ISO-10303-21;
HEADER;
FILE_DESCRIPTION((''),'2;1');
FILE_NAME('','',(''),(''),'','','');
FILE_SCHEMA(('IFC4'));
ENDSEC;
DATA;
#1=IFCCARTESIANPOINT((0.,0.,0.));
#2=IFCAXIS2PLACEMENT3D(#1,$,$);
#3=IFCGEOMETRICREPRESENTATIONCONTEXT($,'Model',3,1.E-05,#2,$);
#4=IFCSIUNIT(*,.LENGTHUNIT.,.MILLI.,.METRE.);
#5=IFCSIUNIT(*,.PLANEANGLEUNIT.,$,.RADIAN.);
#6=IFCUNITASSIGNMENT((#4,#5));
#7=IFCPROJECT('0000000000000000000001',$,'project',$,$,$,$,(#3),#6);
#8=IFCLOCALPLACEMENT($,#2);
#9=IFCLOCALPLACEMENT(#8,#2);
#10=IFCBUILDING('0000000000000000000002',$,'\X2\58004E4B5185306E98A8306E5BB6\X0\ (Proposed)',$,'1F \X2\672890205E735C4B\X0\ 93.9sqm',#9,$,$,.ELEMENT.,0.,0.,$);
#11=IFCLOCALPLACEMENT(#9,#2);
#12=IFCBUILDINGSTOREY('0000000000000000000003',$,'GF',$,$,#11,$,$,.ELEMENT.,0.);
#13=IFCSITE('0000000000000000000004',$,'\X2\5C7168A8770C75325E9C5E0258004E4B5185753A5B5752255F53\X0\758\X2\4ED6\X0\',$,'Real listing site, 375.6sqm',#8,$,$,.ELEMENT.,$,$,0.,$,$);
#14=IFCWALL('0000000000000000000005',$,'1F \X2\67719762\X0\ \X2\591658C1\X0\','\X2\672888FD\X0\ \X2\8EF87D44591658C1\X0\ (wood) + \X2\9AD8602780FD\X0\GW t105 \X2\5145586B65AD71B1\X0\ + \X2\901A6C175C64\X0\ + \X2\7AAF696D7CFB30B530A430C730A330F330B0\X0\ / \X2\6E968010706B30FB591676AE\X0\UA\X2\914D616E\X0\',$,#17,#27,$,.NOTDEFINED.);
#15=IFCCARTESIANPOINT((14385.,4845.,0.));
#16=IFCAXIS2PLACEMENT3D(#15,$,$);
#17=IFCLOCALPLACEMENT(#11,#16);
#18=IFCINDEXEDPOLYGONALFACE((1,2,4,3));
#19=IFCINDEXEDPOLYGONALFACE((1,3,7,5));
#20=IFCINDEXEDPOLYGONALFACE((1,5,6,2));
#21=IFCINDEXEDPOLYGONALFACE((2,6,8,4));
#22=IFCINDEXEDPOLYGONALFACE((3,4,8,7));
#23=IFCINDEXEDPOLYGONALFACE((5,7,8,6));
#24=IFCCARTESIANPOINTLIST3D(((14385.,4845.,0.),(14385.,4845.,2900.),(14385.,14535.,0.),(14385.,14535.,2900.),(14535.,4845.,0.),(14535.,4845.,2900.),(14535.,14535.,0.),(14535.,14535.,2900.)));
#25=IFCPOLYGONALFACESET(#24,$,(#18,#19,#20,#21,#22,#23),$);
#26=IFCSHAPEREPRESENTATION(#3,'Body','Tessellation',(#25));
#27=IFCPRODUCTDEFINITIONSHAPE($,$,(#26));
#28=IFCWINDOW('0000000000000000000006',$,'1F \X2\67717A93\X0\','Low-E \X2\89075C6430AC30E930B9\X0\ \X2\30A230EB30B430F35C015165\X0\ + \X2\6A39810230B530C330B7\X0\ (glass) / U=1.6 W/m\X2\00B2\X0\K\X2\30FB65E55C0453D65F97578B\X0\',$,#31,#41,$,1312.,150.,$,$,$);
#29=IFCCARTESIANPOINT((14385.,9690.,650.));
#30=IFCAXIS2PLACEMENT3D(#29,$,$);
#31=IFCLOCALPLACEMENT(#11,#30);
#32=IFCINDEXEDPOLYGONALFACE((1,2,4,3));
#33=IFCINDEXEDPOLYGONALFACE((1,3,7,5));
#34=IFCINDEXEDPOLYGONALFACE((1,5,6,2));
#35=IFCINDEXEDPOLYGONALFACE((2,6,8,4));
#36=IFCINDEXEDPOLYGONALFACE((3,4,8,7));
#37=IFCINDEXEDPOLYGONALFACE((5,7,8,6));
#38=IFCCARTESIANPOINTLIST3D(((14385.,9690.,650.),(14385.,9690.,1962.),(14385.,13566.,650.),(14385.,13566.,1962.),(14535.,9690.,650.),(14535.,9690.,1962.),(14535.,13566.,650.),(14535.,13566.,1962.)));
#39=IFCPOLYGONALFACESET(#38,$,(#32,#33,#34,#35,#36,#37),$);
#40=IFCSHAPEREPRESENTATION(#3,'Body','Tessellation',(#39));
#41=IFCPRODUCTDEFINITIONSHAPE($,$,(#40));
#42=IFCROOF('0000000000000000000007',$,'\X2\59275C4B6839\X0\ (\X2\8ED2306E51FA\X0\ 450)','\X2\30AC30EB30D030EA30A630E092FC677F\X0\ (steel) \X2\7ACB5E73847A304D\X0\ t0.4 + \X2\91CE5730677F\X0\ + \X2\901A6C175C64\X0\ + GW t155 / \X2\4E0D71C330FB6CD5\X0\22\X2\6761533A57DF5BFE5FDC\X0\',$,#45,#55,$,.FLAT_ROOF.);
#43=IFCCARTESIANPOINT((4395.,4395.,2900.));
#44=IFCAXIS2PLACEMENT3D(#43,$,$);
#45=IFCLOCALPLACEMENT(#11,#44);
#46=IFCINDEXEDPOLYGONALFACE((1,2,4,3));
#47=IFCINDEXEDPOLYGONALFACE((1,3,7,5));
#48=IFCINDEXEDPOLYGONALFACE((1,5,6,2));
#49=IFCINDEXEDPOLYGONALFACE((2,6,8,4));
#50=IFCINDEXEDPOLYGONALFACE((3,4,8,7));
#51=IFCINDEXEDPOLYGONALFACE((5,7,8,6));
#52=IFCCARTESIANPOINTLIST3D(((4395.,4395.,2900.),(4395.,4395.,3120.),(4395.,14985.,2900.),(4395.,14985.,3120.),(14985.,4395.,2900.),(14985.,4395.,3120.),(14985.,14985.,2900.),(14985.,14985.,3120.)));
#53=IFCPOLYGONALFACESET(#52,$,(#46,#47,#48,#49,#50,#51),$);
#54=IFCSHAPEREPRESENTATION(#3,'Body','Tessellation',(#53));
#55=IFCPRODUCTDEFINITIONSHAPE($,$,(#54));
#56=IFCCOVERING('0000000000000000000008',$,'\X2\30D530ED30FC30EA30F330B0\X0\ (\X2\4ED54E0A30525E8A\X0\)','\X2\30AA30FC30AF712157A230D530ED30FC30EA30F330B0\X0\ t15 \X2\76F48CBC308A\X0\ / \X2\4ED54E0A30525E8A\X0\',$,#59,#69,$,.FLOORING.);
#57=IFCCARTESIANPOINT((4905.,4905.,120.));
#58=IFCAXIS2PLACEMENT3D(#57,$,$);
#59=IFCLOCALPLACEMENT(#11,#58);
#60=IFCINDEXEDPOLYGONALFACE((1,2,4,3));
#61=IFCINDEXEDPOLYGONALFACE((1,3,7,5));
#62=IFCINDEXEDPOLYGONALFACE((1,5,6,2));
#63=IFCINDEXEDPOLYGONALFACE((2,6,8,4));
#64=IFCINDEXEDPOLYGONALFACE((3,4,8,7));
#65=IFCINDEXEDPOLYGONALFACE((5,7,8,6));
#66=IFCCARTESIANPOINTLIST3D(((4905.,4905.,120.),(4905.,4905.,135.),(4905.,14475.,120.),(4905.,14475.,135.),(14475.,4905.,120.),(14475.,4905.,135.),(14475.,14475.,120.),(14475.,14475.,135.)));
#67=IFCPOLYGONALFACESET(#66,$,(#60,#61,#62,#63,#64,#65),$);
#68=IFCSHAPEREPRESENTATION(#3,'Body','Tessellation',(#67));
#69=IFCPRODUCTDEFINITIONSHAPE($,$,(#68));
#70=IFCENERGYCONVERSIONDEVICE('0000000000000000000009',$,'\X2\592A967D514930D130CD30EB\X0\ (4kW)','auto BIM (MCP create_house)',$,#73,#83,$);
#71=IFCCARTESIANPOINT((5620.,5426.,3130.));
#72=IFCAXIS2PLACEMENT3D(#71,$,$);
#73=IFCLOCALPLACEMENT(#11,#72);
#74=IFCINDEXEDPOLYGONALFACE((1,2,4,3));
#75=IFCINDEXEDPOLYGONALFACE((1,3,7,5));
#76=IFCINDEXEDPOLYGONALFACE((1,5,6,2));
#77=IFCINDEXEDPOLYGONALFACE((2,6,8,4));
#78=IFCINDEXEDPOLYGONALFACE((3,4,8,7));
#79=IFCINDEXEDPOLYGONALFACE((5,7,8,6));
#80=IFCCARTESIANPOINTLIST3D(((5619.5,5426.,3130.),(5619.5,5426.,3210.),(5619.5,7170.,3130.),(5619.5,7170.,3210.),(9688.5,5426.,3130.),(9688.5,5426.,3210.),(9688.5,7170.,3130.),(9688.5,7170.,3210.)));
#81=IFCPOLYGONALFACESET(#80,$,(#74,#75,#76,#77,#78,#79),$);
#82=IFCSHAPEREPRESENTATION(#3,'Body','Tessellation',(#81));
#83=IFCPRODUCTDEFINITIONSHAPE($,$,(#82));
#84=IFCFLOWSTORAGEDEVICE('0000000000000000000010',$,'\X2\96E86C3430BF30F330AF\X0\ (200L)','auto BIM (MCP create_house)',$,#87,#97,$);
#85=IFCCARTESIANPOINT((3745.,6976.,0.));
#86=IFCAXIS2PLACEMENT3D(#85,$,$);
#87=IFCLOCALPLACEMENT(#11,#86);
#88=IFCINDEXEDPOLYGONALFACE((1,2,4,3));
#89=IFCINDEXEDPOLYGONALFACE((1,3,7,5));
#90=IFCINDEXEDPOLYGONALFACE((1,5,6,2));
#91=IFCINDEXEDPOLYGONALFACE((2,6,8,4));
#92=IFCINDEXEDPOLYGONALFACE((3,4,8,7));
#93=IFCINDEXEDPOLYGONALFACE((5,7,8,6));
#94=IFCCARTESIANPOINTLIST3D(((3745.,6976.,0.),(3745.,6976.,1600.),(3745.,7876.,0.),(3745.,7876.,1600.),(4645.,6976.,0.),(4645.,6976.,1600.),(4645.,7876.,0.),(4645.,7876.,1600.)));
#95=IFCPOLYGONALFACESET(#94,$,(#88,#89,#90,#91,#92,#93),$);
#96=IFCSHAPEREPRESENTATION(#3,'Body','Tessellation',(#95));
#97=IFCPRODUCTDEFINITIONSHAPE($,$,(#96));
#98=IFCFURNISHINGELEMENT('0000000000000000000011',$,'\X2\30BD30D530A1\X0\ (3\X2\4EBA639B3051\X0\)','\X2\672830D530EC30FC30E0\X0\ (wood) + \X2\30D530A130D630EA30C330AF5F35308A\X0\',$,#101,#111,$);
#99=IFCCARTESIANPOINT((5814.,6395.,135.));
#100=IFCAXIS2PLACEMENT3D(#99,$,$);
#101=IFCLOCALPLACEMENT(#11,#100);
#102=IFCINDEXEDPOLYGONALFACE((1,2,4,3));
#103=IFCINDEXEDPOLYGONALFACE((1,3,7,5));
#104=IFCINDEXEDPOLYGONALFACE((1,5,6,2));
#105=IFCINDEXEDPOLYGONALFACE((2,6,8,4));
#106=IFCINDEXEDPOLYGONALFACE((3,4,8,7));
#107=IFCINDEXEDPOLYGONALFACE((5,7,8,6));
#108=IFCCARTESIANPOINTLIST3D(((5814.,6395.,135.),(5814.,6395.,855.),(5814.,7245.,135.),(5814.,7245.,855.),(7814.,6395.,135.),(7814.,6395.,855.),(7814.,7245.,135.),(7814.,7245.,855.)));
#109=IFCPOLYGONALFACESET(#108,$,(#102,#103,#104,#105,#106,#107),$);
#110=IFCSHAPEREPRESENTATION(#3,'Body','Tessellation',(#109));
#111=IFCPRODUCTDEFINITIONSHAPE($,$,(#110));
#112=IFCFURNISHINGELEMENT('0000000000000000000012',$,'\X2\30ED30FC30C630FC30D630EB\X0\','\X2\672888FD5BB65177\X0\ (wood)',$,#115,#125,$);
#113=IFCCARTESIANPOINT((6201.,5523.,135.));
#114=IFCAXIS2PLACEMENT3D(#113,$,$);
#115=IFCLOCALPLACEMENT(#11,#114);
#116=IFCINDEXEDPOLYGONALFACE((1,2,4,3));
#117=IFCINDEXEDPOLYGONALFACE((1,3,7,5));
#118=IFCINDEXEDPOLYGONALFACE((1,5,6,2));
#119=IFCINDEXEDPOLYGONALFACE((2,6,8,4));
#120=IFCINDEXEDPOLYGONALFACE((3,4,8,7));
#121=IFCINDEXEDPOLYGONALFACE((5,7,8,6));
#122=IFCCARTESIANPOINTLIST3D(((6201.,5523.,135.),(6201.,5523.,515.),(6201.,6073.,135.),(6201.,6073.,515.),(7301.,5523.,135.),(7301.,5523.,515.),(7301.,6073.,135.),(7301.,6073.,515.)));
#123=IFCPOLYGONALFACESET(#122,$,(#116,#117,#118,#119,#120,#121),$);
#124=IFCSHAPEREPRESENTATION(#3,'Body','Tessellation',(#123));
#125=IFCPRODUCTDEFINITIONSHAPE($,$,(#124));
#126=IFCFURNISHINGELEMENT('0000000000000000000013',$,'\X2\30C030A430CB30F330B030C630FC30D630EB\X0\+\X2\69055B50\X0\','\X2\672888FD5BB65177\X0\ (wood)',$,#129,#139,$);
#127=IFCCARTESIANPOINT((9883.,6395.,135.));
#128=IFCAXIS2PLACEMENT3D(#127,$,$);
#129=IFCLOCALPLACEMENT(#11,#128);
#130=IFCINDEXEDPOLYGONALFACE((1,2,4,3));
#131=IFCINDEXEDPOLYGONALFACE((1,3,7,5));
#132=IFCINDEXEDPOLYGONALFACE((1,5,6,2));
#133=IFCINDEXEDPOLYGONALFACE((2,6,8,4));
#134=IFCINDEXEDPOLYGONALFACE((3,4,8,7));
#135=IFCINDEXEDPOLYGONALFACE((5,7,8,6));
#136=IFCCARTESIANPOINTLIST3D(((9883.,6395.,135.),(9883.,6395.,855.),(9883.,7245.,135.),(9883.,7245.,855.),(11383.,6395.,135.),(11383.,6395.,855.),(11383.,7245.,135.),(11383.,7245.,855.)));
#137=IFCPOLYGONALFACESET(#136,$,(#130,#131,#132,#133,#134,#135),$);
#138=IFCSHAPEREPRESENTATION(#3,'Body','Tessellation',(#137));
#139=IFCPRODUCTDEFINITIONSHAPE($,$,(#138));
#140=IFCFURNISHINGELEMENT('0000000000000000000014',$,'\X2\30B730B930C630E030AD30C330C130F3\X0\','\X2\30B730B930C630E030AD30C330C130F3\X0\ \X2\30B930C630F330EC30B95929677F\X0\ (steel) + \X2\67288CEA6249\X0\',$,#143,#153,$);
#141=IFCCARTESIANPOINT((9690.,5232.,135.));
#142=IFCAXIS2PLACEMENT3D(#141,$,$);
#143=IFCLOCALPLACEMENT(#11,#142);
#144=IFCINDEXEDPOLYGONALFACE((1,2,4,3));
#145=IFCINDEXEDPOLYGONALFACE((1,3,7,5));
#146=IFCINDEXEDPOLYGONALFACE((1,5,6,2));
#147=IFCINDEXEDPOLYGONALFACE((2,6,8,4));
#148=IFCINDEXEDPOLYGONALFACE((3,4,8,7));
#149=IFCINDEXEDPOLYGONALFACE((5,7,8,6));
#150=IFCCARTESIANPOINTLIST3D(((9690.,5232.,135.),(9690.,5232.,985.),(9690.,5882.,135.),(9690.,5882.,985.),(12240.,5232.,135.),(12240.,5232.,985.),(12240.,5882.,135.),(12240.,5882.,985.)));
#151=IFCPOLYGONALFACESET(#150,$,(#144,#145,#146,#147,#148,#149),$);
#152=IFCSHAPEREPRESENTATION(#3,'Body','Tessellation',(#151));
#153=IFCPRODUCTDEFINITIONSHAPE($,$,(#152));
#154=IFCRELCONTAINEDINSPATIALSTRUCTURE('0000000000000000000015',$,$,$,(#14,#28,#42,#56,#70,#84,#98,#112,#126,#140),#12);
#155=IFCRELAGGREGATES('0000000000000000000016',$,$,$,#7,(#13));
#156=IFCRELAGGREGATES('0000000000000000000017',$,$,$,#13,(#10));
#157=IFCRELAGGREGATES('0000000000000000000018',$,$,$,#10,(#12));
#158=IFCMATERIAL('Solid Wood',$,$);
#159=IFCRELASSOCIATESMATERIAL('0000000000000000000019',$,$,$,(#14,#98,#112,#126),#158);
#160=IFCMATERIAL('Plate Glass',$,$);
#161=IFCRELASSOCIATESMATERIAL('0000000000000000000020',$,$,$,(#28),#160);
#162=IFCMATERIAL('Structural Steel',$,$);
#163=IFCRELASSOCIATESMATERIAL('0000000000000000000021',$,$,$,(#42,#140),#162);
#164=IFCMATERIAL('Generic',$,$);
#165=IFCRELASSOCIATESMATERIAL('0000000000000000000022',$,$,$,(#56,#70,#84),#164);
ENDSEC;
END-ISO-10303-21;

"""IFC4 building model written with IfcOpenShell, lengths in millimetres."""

from ifc_helpers import new_model, si_unit, frame, frame_2d, origin, place, context, project, spatial, rectangle, extrude, material, element, fill, save


model = new_model("IFC4")

# Units and contexts
model_context = context("Model", 3, precision=1e-05, world=origin())
ifc_project = project(units=[si_unit("LENGTHUNIT", "METRE", prefix="MILLI"), si_unit("PLANEANGLEUNIT", "RADIAN")], contexts=[model_context])

# Site, building, storey
site_placement = place(None, origin())
site = spatial("IfcSite", under=ifc_project, at=site_placement, Name="山梨県甲府市堀之内町字別当758他", ObjectType="Real listing site, 375.6sqm", CompositionType="ELEMENT", RefElevation=0.0)
building_placement = place(site_placement, origin())
building = spatial("IfcBuilding", under=site, at=building_placement, Name="堀之内の風の家 (Proposed)", ObjectType="1F 木造平屋 93.9sqm", CompositionType="ELEMENT", ElevationOfRefHeight=0.0, ElevationOfTerrain=0.0)
storey_placement = place(building_placement, origin())
storey = spatial("IfcBuildingStorey", under=building, at=storey_placement, Name="GF", CompositionType="ELEMENT", Elevation=0.0)

# Shared definitions
ifc_material_1 = material(Name="Solid Wood")

# Shared definitions
ifc_material_2 = material(Name="Plate Glass")

# Wall, opening, window
wall_1_placement = place(storey_placement, frame((14385.0, 4845.0, 0.0)))
wall_1 = element("IfcWall", 1, at=wall_1_placement, inside=storey, material=ifc_material_1, Name="1F 東面 外壁", Description="木製 軸組外壁 (wood) + 高性能GW t105 充填断熱 + 通気層 + 窯業系サイディング / 準耐火・外皮UA配慮", PredefinedType="NOTDEFINED", context=model_context, shape_type="SweptSolid", body=[
    extrude(rectangle(XDim=150.0, YDim=9690.0, at=frame_2d((75.0, 4845.0))), frame((14385.0, 4845.0, 0.0)), (0.0, 0.0, 1.0), 2900.0),
])
opening_1_placement = place(storey_placement, frame((14385.0, 9690.0, 650.0)))
opening_1 = element("IfcOpeningElement", 2, at=opening_1_placement, cuts=wall_1, PredefinedType="NOTDEFINED", context=model_context, shape_type="SweptSolid", body=[
    extrude(rectangle(XDim=150.0, YDim=3876.0, at=frame_2d((75.0, 1938.0))), frame((14385.0, 9690.0, 650.0)), (0.0, 0.0, 1.0), 1312.0),
])
window_1_placement = place(storey_placement, frame((14385.0, 9690.0, 650.0)))
window_1 = element("IfcWindow", 3, at=window_1_placement, inside=storey, material=ifc_material_2, Name="1F 東窓", Description="Low-E 複層ガラス アルゴン封入 + 樹脂サッシ (glass) / U=1.6 W/m²K・日射取得型", OverallHeight=1312.0, OverallWidth=150.0, context=model_context, shape_type="SweptSolid", body=[
    extrude(rectangle(XDim=150.0, YDim=3876.0, at=frame_2d((75.0, 1938.0))), frame((14385.0, 9690.0, 650.0)), (0.0, 0.0, 1.0), 1312.0),
])
fill(opening_1, window_1)

# Roof
ifc_material_3 = material(Name="Structural Steel")
roof_placement = place(storey_placement, frame((4395.0, 4395.0, 2900.0)))
element("IfcRoof", 4, at=roof_placement, inside=storey, material=ifc_material_3, Name="大屋根 (軒の出 450)", Description="ガルバリウム鋼板 (steel) 立平葺き t0.4 + 野地板 + 通気層 + GW t155 / 不燃・法22条区域対応", PredefinedType="FLAT_ROOF", context=model_context, shape_type="SweptSolid", body=[
    extrude(rectangle(XDim=10590.0, YDim=10590.0, at=frame_2d((5295.0, 5295.0))), frame((4395.0, 4395.0, 2900.0)), (0.0, 0.0, 1.0), 220.0),
])

# Covering
ifc_material_4 = material(Name="Generic")
covering_placement = place(storey_placement, frame((4905.0, 4905.0, 120.0)))
element("IfcCovering", 5, at=covering_placement, inside=storey, material=ifc_material_4, Name="フローリング (仕上げ床)", Description="オーク無垢フローリング t15 直貼り / 仕上げ床", PredefinedType="FLOORING", context=model_context, shape_type="SweptSolid", body=[
    extrude(rectangle(XDim=9570.0, YDim=9570.0, at=frame_2d((4785.0, 4785.0))), frame((4905.0, 4905.0, 120.0)), (0.0, 0.0, 1.0), 15.0),
])

# Energy conversion device
energy_conversion_device_placement = place(storey_placement, frame((5620.0, 5426.0, 3130.0)))
element("IfcEnergyConversionDevice", 6, at=energy_conversion_device_placement, inside=storey, material=ifc_material_4, Name="太陽光パネル (4kW)", Description="auto BIM (MCP create_house)", context=model_context, shape_type="SweptSolid", body=[
    extrude(rectangle(XDim=4069.0, YDim=1744.0, at=frame_2d((2034.0, 872.0))), frame((5620.0, 5426.0, 3130.0)), (0.0, 0.0, 1.0), 80.0),
])

# Flow storage device
flow_storage_device_placement = place(storey_placement, frame((3745.0, 6976.0, 0.0)))
element("IfcFlowStorageDevice", 7, at=flow_storage_device_placement, inside=storey, material=ifc_material_4, Name="雨水タンク (200L)", Description="auto BIM (MCP create_house)", context=model_context, shape_type="SweptSolid", body=[
    extrude(rectangle(XDim=900.0, YDim=900.0, at=frame_2d((450.0, 450.0))), frame((3745.0, 6976.0, 0.0)), (0.0, 0.0, 1.0), 1600.0),
])

# Furnishing elements
furnishing_1_placement = place(storey_placement, frame((5814.0, 6395.0, 135.0)))
element("IfcFurnishingElement", 8, at=furnishing_1_placement, inside=storey, material=ifc_material_1, Name="ソファ (3人掛け)", Description="木フレーム (wood) + ファブリック張り", context=model_context, shape_type="SweptSolid", body=[
    extrude(rectangle(XDim=2000.0, YDim=850.0, at=frame_2d((1000.0, 425.0))), frame((5814.0, 6395.0, 135.0)), (0.0, 0.0, 1.0), 720.0),
])
furnishing_2_placement = place(storey_placement, frame((6201.0, 5523.0, 135.0)))
element("IfcFurnishingElement", 9, at=furnishing_2_placement, inside=storey, material=ifc_material_1, Name="ローテーブル", Description="木製家具 (wood)", context=model_context, shape_type="SweptSolid", body=[
    extrude(rectangle(XDim=1100.0, YDim=550.0, at=frame_2d((550.0, 275.0))), frame((6201.0, 5523.0, 135.0)), (0.0, 0.0, 1.0), 380.0),
])
furnishing_3_placement = place(storey_placement, frame((9883.0, 6395.0, 135.0)))
element("IfcFurnishingElement", 10, at=furnishing_3_placement, inside=storey, material=ifc_material_1, Name="ダイニングテーブル+椅子", Description="木製家具 (wood)", context=model_context, shape_type="SweptSolid", body=[
    extrude(rectangle(XDim=1500.0, YDim=850.0, at=frame_2d((750.0, 425.0))), frame((9883.0, 6395.0, 135.0)), (0.0, 0.0, 1.0), 720.0),
])
furnishing_4_placement = place(storey_placement, frame((9690.0, 5232.0, 135.0)))
element("IfcFurnishingElement", 11, at=furnishing_4_placement, inside=storey, material=ifc_material_3, Name="システムキッチン", Description="システムキッチン ステンレス天板 (steel) + 木質扉", context=model_context, shape_type="SweptSolid", body=[
    extrude(rectangle(XDim=2550.0, YDim=650.0, at=frame_2d((1275.0, 325.0))), frame((9690.0, 5232.0, 135.0)), (0.0, 0.0, 1.0), 850.0),
])

save(model, "model.ifc")
